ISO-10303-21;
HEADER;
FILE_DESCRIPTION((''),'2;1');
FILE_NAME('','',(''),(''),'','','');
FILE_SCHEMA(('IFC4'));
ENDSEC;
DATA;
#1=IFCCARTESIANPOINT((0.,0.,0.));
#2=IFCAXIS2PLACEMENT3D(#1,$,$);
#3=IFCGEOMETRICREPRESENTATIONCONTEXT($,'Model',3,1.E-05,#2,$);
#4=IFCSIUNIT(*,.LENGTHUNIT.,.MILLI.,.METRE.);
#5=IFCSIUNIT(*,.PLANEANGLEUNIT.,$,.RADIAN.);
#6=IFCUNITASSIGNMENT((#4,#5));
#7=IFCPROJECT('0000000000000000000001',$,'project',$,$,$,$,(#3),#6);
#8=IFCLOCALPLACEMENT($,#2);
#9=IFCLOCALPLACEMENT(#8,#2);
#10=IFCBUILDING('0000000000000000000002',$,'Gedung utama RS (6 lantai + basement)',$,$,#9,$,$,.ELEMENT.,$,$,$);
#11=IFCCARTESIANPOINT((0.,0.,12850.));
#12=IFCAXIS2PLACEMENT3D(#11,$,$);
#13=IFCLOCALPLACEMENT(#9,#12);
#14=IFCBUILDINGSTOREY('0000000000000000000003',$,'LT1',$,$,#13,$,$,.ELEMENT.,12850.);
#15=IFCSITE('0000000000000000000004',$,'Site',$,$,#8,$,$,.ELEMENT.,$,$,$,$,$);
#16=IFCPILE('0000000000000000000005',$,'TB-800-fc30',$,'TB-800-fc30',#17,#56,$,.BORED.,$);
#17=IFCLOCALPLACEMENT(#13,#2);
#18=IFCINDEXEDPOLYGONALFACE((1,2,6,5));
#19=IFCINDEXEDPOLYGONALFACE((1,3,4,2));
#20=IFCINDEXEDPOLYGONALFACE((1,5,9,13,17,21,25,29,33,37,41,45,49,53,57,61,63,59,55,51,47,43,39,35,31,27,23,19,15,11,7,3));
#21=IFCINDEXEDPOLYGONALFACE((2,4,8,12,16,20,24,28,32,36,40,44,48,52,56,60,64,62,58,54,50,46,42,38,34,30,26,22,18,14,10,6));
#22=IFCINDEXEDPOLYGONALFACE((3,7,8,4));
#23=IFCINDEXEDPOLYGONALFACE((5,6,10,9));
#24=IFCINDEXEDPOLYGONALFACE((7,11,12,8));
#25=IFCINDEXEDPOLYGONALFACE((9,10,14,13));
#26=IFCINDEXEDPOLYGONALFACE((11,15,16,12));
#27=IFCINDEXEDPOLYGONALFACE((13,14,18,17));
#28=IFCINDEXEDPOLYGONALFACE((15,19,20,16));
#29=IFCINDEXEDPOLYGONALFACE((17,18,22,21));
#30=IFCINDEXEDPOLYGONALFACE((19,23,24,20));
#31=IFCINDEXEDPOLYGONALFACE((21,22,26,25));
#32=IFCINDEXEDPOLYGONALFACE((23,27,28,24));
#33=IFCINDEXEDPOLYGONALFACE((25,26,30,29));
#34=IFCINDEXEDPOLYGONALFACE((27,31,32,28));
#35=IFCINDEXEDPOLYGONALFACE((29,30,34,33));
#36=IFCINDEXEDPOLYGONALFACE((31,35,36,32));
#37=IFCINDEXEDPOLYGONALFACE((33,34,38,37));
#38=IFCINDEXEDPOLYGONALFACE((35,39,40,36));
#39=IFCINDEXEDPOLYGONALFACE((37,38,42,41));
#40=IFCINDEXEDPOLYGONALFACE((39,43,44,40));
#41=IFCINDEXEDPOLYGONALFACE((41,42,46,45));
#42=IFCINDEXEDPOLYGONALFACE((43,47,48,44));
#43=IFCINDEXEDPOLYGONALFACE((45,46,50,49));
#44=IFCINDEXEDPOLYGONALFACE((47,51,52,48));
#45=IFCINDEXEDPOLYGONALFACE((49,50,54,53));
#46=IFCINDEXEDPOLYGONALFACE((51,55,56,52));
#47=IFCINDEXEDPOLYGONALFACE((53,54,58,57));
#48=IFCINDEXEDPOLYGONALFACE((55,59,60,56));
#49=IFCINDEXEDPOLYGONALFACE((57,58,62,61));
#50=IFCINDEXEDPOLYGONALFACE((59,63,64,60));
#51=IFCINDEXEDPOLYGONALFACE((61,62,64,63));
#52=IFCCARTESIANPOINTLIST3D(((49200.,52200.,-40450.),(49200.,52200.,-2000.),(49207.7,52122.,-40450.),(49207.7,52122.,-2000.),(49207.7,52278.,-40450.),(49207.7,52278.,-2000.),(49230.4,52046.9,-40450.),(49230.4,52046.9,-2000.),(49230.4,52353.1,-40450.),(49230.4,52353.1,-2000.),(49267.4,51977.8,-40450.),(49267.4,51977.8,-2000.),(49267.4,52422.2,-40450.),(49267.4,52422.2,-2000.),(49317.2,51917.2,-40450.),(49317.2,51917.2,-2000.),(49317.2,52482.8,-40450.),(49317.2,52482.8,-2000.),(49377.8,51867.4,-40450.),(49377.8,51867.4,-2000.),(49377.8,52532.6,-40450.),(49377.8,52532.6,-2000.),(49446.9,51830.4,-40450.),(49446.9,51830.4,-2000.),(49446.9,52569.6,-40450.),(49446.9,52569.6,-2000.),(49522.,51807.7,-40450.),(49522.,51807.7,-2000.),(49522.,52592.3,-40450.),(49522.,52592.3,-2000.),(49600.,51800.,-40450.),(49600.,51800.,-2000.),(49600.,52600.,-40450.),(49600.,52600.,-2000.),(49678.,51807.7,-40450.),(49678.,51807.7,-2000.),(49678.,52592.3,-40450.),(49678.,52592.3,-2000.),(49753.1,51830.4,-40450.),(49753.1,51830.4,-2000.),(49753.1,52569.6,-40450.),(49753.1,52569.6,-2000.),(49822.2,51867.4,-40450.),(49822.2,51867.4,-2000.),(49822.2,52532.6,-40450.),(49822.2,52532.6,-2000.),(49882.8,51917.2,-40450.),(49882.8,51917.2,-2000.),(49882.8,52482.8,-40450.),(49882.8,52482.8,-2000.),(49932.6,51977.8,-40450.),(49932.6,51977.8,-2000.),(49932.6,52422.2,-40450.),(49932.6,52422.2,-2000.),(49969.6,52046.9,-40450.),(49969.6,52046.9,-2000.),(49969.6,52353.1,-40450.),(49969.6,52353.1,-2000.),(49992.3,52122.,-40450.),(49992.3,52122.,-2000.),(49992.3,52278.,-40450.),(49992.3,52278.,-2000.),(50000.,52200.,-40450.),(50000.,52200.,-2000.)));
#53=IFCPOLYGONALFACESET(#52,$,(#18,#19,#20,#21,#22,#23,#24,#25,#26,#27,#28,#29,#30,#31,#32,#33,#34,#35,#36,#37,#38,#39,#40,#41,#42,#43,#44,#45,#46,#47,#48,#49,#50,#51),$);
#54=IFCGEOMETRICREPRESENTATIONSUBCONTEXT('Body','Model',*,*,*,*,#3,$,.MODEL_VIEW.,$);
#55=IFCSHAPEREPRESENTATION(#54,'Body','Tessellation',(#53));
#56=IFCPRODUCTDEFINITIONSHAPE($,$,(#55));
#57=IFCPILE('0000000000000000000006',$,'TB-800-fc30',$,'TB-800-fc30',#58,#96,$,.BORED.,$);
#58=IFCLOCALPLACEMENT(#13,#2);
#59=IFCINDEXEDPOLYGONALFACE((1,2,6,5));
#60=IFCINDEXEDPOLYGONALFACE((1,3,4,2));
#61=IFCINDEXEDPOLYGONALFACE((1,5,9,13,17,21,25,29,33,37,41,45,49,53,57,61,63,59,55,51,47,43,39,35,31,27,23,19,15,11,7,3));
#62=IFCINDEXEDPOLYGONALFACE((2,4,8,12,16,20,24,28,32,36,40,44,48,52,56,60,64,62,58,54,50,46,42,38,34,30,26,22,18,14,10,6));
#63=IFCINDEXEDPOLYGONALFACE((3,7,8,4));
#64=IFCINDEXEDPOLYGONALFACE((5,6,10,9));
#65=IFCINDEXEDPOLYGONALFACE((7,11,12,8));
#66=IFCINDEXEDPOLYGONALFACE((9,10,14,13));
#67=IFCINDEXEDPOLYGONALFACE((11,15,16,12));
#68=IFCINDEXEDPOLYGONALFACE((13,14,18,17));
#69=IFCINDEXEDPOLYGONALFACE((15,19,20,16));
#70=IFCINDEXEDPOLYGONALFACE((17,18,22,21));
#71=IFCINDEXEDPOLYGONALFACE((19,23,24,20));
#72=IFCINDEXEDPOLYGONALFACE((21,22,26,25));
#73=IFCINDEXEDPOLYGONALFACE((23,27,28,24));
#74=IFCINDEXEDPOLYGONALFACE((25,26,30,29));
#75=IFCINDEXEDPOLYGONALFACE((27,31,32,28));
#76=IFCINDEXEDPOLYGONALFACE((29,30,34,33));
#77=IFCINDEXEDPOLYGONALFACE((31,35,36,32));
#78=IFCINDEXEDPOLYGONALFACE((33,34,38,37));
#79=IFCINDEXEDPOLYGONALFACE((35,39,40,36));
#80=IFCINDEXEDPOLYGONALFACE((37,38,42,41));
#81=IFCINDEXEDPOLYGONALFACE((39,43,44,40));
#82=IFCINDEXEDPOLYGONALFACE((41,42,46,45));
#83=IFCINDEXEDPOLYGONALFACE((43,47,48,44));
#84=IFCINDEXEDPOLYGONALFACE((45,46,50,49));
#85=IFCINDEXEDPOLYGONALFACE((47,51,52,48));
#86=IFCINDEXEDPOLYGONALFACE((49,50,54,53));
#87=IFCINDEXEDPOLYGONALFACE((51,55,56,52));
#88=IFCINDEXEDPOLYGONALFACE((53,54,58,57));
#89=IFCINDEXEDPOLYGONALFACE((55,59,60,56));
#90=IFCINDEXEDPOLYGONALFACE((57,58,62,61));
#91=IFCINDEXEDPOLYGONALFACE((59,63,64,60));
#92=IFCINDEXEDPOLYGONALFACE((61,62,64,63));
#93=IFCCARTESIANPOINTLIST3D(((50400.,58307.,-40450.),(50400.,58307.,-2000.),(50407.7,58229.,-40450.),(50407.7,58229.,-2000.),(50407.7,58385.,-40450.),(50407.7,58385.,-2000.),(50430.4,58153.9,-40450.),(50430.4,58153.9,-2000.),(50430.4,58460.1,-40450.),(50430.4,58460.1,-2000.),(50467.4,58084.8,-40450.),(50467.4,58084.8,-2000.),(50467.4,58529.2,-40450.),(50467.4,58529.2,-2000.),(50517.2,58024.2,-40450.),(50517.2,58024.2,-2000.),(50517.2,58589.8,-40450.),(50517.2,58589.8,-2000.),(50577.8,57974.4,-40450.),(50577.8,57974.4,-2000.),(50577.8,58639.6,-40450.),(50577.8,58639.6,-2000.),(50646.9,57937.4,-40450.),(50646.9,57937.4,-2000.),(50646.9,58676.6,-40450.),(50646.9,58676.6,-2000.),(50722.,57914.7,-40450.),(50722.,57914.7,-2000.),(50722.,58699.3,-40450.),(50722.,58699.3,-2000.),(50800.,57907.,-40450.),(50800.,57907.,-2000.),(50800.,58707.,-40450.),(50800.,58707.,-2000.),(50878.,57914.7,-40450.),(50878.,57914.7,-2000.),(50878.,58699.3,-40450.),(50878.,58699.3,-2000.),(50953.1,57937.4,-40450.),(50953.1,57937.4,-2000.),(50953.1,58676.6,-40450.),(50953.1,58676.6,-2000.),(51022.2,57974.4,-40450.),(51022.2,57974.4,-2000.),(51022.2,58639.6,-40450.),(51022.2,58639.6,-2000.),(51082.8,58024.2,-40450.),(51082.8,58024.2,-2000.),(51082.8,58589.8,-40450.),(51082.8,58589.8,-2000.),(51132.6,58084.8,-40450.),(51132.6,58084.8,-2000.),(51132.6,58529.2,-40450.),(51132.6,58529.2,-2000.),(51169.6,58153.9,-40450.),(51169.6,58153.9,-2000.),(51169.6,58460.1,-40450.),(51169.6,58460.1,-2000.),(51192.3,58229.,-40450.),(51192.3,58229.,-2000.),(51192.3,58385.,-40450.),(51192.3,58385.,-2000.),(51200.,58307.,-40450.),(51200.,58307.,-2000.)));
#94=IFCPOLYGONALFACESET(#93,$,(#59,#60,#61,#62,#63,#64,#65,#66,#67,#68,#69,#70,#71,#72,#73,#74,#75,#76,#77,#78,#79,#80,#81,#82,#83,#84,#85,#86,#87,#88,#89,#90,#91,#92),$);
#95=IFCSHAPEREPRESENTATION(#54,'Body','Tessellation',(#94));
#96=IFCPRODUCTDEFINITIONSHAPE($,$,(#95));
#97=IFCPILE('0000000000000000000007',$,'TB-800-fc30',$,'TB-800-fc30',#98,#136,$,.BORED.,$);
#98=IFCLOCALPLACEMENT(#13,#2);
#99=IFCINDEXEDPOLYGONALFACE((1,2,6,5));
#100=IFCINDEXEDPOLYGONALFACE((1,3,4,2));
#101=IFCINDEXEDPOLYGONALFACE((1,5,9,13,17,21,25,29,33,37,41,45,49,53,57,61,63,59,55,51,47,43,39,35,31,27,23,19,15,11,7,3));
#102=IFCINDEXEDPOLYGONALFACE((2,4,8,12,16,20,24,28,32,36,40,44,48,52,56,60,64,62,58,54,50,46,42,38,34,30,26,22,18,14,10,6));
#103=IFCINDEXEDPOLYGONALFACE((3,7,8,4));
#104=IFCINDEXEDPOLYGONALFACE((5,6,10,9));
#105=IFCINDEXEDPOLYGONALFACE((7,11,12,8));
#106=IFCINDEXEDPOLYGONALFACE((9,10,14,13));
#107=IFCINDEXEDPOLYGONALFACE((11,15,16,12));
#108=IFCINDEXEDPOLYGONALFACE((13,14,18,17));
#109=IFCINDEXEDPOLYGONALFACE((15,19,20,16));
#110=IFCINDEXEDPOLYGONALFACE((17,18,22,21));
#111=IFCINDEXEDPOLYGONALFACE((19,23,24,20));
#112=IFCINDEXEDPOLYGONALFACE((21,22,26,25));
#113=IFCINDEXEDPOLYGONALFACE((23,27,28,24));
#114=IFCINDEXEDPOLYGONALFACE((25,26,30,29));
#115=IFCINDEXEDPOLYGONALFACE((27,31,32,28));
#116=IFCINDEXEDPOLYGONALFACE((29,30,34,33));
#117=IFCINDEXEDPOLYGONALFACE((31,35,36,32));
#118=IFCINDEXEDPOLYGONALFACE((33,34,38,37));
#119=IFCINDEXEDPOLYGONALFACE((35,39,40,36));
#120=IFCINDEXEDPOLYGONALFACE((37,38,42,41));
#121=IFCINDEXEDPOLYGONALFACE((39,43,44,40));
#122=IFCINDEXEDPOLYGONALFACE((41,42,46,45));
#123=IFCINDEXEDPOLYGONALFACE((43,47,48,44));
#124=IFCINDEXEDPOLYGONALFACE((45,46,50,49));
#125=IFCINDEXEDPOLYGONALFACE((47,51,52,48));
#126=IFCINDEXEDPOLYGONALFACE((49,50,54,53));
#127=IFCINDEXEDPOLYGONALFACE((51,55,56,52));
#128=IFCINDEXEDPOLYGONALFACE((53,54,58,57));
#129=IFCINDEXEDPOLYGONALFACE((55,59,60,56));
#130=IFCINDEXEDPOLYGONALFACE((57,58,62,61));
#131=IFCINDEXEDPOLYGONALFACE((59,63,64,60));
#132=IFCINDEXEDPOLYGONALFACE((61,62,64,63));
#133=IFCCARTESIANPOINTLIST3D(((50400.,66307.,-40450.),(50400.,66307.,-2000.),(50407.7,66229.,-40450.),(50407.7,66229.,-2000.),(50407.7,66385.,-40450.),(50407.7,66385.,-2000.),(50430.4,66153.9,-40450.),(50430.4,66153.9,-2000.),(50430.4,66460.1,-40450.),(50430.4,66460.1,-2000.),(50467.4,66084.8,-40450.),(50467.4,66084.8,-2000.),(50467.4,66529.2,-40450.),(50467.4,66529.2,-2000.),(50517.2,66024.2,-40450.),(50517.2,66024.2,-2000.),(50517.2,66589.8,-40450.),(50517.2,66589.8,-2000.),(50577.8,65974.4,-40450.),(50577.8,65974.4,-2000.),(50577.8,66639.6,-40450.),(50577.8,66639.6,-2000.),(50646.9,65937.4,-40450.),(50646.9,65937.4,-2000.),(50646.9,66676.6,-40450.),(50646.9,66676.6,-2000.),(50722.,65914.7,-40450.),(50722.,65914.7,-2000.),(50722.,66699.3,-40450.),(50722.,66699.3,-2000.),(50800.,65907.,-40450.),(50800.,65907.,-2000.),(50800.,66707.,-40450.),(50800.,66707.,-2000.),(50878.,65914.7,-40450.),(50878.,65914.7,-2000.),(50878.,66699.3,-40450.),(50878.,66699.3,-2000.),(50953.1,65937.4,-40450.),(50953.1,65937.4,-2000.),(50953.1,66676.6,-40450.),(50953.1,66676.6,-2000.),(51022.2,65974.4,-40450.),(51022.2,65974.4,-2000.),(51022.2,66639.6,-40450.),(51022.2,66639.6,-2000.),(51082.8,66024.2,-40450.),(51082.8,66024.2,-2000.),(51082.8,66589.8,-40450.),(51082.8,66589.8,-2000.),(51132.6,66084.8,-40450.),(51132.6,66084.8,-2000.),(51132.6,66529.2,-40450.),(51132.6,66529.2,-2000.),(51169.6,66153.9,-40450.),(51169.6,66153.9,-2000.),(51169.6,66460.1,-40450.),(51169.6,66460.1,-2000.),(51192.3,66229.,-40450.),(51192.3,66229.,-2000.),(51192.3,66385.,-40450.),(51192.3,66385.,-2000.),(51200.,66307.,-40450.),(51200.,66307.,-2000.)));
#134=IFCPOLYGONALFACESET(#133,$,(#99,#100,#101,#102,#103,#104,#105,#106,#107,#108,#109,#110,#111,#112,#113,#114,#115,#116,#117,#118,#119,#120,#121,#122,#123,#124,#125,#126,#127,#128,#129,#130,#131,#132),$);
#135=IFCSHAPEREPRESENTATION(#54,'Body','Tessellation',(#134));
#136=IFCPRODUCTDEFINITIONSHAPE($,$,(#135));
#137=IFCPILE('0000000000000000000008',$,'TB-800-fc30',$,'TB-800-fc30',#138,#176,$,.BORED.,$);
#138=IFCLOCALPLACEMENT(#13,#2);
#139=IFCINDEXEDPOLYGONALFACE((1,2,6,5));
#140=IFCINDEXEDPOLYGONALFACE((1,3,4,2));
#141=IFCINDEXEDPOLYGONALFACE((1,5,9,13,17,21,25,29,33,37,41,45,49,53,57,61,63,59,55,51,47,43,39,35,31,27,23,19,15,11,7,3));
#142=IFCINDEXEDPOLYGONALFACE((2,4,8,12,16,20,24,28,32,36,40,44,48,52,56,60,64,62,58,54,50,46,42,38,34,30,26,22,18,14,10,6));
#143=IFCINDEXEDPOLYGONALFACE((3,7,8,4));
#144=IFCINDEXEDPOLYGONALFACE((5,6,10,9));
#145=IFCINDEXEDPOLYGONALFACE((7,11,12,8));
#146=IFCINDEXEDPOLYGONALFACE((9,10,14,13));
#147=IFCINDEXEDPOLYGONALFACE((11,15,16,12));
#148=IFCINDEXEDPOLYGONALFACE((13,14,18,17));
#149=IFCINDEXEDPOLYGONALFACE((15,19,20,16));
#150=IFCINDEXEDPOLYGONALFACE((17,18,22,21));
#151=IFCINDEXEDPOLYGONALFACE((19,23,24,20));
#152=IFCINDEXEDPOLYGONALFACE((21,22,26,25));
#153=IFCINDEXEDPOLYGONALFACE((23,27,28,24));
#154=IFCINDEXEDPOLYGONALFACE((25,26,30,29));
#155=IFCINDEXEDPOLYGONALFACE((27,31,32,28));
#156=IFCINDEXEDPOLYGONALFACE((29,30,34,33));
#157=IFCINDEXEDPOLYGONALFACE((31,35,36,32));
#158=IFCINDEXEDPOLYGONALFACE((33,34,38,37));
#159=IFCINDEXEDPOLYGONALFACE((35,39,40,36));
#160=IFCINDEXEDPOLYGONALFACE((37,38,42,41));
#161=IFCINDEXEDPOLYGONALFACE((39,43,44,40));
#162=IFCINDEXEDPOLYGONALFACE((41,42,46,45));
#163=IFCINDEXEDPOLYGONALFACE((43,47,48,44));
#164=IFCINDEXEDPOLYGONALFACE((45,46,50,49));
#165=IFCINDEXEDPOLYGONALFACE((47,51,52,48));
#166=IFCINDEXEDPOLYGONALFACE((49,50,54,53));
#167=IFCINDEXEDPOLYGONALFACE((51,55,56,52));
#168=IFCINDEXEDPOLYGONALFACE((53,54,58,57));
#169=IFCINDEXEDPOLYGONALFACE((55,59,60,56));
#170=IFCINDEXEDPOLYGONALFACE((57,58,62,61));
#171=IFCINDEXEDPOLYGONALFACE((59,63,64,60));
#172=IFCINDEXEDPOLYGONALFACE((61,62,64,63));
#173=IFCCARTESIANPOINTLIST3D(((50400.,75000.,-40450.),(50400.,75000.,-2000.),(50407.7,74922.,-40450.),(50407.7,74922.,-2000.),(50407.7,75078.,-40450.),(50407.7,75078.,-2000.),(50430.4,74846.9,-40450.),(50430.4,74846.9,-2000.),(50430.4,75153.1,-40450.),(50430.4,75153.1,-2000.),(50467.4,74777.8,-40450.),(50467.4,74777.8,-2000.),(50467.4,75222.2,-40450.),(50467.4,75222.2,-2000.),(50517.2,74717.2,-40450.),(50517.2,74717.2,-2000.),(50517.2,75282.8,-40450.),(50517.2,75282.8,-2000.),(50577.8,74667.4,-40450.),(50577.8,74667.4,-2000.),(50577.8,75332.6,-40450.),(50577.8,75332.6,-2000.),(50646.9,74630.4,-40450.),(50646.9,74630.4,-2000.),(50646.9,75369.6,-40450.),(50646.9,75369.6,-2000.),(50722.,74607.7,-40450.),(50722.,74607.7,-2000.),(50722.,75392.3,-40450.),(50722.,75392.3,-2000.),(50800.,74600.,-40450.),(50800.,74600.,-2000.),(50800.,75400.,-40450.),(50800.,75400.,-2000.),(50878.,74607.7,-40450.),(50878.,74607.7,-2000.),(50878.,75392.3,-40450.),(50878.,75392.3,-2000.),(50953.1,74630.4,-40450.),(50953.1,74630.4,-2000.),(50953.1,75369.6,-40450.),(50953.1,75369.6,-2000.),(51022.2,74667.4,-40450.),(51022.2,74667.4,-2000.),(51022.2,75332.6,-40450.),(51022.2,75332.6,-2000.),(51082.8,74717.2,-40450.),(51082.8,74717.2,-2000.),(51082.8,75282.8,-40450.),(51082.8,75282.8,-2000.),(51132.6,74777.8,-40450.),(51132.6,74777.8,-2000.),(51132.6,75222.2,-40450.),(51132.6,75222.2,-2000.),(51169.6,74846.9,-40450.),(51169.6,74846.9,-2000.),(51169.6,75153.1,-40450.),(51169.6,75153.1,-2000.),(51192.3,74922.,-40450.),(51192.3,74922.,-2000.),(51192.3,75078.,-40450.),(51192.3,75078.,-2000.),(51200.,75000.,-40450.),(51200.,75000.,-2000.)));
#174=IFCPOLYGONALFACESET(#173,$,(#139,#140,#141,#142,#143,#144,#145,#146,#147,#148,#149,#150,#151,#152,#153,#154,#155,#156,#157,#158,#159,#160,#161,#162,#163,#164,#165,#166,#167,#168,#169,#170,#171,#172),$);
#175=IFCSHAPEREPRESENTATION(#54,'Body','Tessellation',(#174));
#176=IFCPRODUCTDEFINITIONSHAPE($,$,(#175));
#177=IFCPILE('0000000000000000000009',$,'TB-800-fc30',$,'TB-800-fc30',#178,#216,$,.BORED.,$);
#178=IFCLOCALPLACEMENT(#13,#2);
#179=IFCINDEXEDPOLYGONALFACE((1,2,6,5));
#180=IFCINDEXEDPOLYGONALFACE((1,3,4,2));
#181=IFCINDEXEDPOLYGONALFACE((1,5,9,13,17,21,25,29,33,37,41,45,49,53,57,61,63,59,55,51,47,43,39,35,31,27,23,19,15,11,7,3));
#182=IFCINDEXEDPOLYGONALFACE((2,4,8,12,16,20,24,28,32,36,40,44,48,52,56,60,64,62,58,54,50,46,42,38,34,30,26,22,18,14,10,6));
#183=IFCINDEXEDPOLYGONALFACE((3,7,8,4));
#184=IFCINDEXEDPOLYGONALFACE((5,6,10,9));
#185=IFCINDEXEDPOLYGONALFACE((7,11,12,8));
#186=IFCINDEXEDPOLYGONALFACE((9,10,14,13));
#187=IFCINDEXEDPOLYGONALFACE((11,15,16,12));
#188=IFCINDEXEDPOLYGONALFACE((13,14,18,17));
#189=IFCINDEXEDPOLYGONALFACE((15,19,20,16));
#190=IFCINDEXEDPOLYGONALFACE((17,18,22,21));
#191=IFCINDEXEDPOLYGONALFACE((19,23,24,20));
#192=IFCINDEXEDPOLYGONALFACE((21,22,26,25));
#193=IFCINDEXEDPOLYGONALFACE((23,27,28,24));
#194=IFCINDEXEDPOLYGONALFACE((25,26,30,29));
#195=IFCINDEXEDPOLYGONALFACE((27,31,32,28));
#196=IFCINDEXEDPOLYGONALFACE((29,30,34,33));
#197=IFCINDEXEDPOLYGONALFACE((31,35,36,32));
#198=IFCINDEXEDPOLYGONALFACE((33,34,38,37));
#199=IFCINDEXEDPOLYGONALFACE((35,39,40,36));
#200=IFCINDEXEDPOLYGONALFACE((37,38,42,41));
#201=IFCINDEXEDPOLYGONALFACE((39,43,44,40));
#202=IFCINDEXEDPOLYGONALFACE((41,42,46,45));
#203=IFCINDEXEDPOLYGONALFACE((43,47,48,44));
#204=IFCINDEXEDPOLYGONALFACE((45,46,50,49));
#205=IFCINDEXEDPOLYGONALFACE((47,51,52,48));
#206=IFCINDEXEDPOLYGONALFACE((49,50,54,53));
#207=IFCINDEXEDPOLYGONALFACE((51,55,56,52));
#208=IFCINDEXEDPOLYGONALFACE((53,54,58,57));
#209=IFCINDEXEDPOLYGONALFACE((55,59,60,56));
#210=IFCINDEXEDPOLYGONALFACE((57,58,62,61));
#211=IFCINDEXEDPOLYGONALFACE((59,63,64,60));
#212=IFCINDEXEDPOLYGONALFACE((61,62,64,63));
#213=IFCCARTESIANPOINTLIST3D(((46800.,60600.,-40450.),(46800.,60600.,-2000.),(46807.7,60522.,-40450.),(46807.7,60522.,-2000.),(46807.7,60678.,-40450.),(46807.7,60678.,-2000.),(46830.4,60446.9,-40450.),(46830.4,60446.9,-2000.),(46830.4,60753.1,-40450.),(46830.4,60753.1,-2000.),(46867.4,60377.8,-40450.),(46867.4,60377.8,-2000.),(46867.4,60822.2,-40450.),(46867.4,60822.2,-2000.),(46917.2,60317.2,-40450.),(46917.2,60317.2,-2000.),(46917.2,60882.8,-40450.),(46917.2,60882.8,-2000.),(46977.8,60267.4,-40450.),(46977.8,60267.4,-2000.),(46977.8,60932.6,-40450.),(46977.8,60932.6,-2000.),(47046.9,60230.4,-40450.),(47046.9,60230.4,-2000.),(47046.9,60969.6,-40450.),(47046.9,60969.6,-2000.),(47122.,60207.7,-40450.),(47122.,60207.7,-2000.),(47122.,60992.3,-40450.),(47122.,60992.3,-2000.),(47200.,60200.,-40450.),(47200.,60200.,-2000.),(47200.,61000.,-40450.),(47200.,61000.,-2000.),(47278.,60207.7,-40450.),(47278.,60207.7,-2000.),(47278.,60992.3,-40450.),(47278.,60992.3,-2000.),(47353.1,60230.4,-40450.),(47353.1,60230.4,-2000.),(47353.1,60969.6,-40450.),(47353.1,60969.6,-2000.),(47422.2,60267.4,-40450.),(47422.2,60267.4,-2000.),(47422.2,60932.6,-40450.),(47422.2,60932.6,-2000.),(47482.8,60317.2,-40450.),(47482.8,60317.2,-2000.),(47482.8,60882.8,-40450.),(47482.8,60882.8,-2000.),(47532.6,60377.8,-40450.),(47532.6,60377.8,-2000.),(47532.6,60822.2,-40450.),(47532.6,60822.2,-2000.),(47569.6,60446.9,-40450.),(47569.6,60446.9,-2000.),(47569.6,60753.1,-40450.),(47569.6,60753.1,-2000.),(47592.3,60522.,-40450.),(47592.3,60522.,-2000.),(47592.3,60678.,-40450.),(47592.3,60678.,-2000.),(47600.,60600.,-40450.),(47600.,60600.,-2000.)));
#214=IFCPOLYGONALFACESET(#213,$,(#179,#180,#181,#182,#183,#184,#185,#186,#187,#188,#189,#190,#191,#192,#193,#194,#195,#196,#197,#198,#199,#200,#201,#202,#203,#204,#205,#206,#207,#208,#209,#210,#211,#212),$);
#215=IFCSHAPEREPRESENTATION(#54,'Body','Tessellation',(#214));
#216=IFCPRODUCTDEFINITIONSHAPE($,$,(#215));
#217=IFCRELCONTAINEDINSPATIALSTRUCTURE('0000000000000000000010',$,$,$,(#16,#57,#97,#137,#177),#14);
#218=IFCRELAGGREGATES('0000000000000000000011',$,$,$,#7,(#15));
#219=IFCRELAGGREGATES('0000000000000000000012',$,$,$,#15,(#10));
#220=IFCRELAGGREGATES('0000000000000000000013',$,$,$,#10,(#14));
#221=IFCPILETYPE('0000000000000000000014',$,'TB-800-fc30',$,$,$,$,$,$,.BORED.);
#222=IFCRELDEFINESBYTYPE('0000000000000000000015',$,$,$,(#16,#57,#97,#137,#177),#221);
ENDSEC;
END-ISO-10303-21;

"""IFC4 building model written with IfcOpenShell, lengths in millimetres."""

from ifc_helpers import new_model, si_unit, frame, origin, origin_2d, place, context, subcontext, project, spatial, circle, extrude, material_profile, profile_set, profile_usage, type_object, element, save


model = new_model("IFC4")

# Units and contexts
model_context = context("Model", 3, precision=1e-05, world=origin())
body_context = subcontext(model_context, "Body", "Model", "MODEL_VIEW")
ifc_project = project(units=[si_unit("LENGTHUNIT", "METRE", prefix="MILLI"), si_unit("PLANEANGLEUNIT", "RADIAN")], contexts=[model_context])

# Site, building, storey
site_placement = place(None, origin())
site = spatial("IfcSite", under=ifc_project, at=site_placement, Name="Site", CompositionType="ELEMENT")
building_placement = place(site_placement, origin())
building = spatial("IfcBuilding", under=site, at=building_placement, Name="Gedung utama RS (6 lantai + basement)", CompositionType="ELEMENT")
storey_placement = place(building_placement, frame((0.0, 0.0, 12850.0)))
storey = spatial("IfcBuildingStorey", under=building, at=storey_placement, Name="LT1", CompositionType="ELEMENT", Elevation=12850.0)

# Piles
ifc_material_profile = material_profile(None, circle(Radius=400.0, at=origin_2d()), Name="TB-800-fc30")
ifc_profile_set = profile_set([ifc_material_profile], Name="TB-800-fc30")
ifc_profile_usage = profile_usage(ifc_profile_set, cardinal=5)
pile_type = type_object("IfcPileType", Name="TB-800-fc30", PredefinedType="BORED", material=ifc_profile_set)
for number, where, z_axis, x_axis, name in (
    (1, (49600.0, 52200.0, -40450.0), (0.0, 0.0, 1.0), (1.0, 0.0, 0.0), "TB-800-fc30"),
    (2, (50800.0, 58307.0, -40450.0), (0.0, 0.0, 1.0), (1.0, 0.0, 0.0), "TB-800-fc30"),
    (3, (50800.0, 66307.0, -40450.0), (0.0, 0.0, 1.0), (1.0, 0.0, 0.0), "TB-800-fc30"),
    (4, (50800.0, 75000.0, -40450.0), (0.0, 0.0, 1.0), (1.0, 0.0, 0.0), "TB-800-fc30"),
    (5, (47200.0, 60600.0, -40450.0), (0.0, 0.0, 1.0), (1.0, 0.0, 0.0), "TB-800-fc30"),
):
    element("IfcPile", number, at=place(storey_placement, frame(where, z_axis=z_axis, x_axis=x_axis)), inside=storey, type_object=pile_type, material=ifc_profile_usage, Name=name, ObjectType="TB-800-fc30", PredefinedType="BORED", context=body_context, shape_type="SweptSolid", body=[
        extrude(circle(Radius=400.0, at=origin_2d()), origin(), (0.0, 0.0, 1.0), 38450.0),
    ])

save(model, "model.ifc")
